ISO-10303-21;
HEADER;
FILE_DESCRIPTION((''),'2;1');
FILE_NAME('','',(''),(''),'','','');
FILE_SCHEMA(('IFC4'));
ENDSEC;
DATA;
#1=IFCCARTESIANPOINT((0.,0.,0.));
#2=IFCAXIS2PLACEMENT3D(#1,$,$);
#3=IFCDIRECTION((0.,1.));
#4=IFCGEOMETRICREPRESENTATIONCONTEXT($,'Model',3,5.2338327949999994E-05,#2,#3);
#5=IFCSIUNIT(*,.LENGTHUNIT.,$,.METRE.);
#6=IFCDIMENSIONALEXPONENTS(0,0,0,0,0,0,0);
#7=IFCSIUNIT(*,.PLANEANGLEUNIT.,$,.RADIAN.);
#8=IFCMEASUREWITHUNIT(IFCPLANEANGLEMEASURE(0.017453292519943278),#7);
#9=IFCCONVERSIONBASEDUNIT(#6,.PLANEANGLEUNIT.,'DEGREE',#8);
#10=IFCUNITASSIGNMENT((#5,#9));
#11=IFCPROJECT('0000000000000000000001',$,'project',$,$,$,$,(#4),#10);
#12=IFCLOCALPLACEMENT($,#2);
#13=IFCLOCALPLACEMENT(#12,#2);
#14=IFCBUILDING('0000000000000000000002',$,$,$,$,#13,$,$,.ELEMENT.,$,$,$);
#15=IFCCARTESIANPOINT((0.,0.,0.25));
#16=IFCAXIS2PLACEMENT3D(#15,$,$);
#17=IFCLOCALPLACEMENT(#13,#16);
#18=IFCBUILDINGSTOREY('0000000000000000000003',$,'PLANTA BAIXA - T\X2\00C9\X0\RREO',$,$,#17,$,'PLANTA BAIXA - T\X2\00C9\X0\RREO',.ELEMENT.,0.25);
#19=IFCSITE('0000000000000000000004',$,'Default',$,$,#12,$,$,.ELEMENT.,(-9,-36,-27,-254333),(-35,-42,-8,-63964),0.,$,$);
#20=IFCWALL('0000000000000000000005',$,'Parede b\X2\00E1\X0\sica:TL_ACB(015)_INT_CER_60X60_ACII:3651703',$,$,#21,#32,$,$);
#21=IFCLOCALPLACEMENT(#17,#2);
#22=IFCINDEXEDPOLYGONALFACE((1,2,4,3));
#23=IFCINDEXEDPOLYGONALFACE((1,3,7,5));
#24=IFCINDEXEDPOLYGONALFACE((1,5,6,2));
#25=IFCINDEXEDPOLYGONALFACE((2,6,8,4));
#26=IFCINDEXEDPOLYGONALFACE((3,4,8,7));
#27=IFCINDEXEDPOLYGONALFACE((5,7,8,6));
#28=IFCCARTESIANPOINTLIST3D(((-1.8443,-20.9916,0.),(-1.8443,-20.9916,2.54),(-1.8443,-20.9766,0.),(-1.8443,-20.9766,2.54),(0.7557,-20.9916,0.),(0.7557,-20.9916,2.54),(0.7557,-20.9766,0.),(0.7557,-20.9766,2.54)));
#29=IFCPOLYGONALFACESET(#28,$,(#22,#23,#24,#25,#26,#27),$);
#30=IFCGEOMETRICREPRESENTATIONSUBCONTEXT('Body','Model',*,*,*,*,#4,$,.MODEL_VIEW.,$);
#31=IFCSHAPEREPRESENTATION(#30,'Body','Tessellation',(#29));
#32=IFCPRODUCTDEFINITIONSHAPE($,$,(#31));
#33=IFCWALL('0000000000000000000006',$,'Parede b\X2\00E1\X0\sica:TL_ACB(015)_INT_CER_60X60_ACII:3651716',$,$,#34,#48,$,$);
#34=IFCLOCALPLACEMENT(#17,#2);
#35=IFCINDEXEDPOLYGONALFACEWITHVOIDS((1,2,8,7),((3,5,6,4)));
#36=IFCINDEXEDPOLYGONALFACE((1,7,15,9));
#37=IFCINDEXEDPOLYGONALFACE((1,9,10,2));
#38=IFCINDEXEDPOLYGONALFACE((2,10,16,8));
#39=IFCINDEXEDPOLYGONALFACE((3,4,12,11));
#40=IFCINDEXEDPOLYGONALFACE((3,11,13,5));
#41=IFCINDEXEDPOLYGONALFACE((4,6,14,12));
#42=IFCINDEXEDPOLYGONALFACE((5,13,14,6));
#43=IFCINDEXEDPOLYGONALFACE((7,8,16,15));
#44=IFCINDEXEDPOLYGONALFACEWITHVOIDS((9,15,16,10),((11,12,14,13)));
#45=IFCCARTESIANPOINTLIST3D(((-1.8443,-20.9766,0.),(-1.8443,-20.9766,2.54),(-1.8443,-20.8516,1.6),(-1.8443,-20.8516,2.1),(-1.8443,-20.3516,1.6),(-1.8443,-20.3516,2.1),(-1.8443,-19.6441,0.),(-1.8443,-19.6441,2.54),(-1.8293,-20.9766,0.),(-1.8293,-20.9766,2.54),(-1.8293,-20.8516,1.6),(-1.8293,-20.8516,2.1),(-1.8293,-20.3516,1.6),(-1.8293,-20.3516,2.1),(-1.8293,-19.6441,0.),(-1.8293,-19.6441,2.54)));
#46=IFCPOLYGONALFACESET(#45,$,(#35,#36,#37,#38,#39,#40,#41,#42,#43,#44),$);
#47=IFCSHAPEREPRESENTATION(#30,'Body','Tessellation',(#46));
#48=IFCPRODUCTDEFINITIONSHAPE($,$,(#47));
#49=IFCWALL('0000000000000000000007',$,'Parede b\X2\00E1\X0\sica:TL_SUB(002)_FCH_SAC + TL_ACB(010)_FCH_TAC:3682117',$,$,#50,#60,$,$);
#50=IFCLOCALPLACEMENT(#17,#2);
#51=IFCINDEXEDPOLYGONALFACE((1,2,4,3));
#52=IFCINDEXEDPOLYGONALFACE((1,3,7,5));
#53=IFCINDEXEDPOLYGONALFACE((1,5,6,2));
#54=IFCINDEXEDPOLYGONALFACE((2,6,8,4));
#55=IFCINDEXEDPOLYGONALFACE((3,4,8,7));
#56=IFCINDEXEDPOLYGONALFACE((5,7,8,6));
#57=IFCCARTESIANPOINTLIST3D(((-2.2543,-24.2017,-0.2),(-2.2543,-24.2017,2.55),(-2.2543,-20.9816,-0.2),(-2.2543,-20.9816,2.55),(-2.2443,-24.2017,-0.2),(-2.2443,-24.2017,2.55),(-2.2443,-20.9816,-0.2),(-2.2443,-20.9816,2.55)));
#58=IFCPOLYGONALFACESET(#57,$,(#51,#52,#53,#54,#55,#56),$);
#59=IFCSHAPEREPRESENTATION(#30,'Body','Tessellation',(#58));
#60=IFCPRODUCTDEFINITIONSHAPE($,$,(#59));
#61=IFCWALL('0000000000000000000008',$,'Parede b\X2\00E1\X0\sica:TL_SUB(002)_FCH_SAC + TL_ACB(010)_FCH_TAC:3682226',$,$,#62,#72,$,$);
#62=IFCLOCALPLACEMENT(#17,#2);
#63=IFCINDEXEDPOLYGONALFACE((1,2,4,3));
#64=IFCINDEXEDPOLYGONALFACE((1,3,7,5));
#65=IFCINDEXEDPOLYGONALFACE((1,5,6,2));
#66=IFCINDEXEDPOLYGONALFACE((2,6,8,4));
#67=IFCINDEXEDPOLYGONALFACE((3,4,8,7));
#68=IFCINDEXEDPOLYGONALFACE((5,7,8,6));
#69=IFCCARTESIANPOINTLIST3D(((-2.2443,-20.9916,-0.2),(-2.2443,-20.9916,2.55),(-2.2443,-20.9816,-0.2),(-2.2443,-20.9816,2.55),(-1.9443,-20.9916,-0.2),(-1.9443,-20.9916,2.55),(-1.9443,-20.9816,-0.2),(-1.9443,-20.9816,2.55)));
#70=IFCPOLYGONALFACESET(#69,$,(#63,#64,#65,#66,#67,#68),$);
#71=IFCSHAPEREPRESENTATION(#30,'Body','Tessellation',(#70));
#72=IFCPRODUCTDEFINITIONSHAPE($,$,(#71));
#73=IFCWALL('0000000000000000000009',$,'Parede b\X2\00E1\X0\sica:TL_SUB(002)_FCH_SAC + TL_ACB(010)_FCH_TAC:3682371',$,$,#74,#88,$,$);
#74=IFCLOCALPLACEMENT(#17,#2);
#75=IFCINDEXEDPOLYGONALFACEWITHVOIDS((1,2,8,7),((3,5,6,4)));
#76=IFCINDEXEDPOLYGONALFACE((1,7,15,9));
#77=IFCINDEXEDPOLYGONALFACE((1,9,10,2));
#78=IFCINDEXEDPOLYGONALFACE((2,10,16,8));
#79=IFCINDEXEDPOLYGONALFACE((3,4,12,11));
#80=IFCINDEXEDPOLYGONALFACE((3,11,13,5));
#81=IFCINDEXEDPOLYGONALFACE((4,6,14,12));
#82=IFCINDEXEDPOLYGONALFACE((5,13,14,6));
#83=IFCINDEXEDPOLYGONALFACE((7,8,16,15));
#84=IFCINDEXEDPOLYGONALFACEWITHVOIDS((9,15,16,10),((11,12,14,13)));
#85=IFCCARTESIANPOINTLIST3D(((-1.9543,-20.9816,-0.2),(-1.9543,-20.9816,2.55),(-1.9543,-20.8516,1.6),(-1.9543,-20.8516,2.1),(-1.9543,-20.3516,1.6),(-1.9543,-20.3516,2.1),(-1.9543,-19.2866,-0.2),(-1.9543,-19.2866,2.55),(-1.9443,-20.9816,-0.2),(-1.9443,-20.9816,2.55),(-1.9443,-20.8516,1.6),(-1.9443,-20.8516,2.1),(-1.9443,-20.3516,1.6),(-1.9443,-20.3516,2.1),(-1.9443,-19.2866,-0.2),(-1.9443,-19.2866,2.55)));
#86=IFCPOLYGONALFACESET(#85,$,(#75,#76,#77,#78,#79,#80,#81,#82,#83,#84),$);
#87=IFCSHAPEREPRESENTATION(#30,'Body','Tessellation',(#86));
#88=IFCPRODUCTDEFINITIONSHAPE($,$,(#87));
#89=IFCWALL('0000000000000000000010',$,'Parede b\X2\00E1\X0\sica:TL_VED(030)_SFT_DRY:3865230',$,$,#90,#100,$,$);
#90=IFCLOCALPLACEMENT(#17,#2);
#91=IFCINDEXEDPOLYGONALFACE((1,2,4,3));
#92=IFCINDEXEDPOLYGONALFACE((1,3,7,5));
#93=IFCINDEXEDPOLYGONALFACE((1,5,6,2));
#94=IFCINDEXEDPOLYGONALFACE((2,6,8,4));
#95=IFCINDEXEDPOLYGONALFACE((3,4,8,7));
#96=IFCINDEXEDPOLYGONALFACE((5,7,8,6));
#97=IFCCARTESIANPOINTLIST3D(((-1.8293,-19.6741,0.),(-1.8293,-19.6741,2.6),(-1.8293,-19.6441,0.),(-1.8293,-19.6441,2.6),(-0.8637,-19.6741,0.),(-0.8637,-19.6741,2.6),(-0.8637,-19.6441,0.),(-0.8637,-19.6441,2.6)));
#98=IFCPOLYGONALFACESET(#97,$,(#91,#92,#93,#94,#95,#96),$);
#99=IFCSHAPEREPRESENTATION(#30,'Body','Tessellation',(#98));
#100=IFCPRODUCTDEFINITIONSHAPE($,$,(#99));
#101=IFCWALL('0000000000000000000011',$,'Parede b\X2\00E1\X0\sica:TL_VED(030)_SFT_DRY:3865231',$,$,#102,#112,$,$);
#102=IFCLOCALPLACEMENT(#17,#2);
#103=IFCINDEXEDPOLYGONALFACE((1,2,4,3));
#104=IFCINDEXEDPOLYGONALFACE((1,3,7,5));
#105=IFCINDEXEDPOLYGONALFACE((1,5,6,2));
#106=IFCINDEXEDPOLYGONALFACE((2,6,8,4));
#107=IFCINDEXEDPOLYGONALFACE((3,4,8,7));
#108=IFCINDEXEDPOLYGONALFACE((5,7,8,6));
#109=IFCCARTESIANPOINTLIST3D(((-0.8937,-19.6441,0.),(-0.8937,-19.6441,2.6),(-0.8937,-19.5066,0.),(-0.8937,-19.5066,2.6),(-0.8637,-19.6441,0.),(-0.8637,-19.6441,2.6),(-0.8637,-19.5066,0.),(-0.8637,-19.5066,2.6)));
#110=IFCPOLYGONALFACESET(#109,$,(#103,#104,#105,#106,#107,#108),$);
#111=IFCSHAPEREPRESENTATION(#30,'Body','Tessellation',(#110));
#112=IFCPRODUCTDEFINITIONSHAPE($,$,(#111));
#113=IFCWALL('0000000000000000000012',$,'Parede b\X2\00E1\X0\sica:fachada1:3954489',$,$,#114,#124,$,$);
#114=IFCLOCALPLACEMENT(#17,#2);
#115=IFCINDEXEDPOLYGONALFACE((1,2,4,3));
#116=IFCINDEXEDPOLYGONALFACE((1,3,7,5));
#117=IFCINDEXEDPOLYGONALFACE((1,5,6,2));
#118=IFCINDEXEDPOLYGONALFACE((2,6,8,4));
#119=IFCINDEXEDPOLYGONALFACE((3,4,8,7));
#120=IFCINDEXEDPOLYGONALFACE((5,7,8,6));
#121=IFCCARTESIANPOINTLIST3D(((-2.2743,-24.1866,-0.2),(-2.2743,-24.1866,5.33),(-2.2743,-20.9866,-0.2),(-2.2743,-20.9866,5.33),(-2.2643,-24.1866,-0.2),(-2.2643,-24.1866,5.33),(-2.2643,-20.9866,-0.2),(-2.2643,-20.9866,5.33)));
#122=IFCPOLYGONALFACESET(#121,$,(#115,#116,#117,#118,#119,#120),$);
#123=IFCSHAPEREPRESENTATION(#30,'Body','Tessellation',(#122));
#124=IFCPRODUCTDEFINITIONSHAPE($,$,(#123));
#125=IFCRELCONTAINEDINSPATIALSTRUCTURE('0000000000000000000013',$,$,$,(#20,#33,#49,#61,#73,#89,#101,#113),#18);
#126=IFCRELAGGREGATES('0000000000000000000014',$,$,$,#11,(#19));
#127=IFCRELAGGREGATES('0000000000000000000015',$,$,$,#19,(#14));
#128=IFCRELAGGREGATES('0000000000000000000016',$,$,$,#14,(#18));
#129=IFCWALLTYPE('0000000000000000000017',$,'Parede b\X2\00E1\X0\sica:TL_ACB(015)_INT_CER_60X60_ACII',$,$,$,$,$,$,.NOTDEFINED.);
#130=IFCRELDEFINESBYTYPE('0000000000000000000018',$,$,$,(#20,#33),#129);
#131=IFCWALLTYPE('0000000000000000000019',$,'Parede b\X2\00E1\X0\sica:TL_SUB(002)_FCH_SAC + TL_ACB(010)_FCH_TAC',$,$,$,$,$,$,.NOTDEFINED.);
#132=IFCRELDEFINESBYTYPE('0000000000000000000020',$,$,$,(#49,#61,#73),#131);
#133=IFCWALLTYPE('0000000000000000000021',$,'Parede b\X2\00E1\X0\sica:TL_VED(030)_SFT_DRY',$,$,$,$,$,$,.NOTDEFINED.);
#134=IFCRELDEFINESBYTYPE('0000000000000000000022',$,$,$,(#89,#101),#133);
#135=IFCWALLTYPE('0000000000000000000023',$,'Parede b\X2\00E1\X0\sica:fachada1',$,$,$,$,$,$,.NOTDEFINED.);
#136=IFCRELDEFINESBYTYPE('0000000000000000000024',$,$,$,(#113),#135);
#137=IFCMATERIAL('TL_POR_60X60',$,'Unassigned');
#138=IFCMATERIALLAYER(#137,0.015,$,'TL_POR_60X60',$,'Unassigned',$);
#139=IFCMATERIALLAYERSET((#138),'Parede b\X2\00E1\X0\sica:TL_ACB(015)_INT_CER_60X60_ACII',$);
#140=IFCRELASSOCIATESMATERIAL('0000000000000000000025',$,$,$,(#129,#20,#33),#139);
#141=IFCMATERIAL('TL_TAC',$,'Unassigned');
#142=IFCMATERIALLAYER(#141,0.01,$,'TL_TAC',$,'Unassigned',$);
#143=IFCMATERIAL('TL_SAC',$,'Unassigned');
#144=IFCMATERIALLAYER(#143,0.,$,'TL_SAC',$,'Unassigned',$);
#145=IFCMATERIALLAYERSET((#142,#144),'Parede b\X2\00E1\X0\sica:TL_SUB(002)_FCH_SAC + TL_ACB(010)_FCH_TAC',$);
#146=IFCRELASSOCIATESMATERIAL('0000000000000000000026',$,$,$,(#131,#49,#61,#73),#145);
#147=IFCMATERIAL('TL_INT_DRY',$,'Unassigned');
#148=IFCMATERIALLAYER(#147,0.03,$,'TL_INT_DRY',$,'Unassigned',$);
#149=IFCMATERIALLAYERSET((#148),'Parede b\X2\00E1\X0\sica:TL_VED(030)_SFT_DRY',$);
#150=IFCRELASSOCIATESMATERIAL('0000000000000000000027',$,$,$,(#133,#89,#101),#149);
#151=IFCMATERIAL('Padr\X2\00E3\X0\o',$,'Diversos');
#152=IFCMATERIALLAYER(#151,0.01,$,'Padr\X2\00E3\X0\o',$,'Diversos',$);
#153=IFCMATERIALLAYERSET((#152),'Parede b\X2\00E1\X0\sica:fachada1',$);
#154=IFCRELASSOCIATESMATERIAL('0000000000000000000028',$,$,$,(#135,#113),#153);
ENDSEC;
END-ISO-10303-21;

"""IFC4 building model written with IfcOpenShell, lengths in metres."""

from ifc_helpers import new_model, entity, si_unit, converted_unit, direction, frame, frame_2d, origin, place, context, subcontext, project, spatial, rectangle, extrude, material, layer, layer_set, layer_usage, type_object, element, save


model = new_model("IFC4")

# Units and contexts
model_context = context("Model", 3, precision=5.2338327949999994e-05, world=origin(), true_north=direction((0.0, 1.0)))
body_context = subcontext(model_context, "Body", "Model", "MODEL_VIEW")
ifc_project = project(units=[si_unit("LENGTHUNIT", "METRE"), converted_unit("PLANEANGLEUNIT", "DEGREE", entity("IfcPlaneAngleMeasure", 0.017453292519943278), si_unit("PLANEANGLEUNIT", "RADIAN"), dimensions=[0, 0, 0, 0, 0, 0, 0])], contexts=[model_context])

# Site, building, storey
site_placement = place(None, frame((0.0, 0.0, 0.0)))
site = spatial("IfcSite", under=ifc_project, at=site_placement, Name="Default", CompositionType="ELEMENT", RefLatitude=(-9, -36, -27, -254333), RefLongitude=(-35, -42, -8, -63964), RefElevation=0.0)
building_placement = place(site_placement, origin())
building = spatial("IfcBuilding", under=site, at=building_placement, CompositionType="ELEMENT")
storey_placement = place(building_placement, frame((0.0, 0.0, 0.25)))
storey = spatial("IfcBuildingStorey", under=building, at=storey_placement, Name="PLANTA BAIXA - TÉRREO", LongName="PLANTA BAIXA - TÉRREO", CompositionType="ELEMENT", Elevation=0.25)

# Shared definitions
ifc_material_1 = material(Name="TL_SAC", Category="Unassigned")

# Wall
ifc_material_2 = material(Name="TL_POR_60X60", Category="Unassigned")
ifc_layer_1 = layer(ifc_material_2, 0.015, Name="TL_POR_60X60", Category="Unassigned")
ifc_layer_set_1 = layer_set([ifc_layer_1], Name="Parede básica:TL_ACB(015)_INT_CER_60X60_ACII")
ifc_layer_usage_1 = layer_usage(ifc_layer_set_1, "AXIS2", "NEGATIVE", 0.0075)
wall_type_1 = type_object("IfcWallType", Name="Parede básica:TL_ACB(015)_INT_CER_60X60_ACII", PredefinedType="NOTDEFINED", material=ifc_layer_set_1)
wall_1_placement = place(storey_placement, frame((-1.8443, -20.9841, 0.0)))
element("IfcWall", 1, at=wall_1_placement, inside=storey, type_object=wall_type_1, material=ifc_layer_usage_1, Name="Parede básica:TL_ACB(015)_INT_CER_60X60_ACII:3651703", context=body_context, shape_type="SweptSolid", body=[
    extrude(rectangle(XDim=2.6, YDim=0.015, at=frame_2d((1.3, 0.0), x_axis=(-1.0, 0.0))), origin(), (0.0, 0.0, 1.0), 2.54),
])

# Wall, opening
ifc_layer_usage_2 = layer_usage(ifc_layer_set_1, "AXIS2", "POSITIVE", -0.0075)
wall_2_placement = place(storey_placement, frame((-1.8368, -20.9766, 0.0), z_axis=(0.0, 0.0, 1.0), x_axis=(0.0, 1.0, 0.0)))
wall_2 = element("IfcWall", 2, at=wall_2_placement, inside=storey, type_object=wall_type_1, material=ifc_layer_usage_2, Name="Parede básica:TL_ACB(015)_INT_CER_60X60_ACII:3651716", context=body_context, shape_type="SweptSolid", body=[
    extrude(rectangle(XDim=1.3325, YDim=0.015, at=frame_2d((0.6662, 0.0), x_axis=(-1.0, 0.0))), origin(), (0.0, 0.0, 1.0), 2.54),
])
opening_1_placement = place(wall_2_placement, frame((20.9766, -1.8368, 1.6)))
element("IfcOpeningElement", 3, at=opening_1_placement, cuts=wall_2, PredefinedType="OPENING", context=body_context, shape_type="SweptSolid", body=[
    extrude(rectangle(XDim=0.5, YDim=0.5, at=frame_2d((0.0, 0.0), x_axis=(1.0, 0.0))), frame((-20.6016, 0.4203, 0.25), z_axis=(0.0, 1.0, 0.0), x_axis=(0.0, 0.0, 1.0)), (0.0, 0.0, 1.0), 3.048),
])

# Walls
ifc_material_3 = material(Name="TL_TAC", Category="Unassigned")
ifc_layer_2 = layer(ifc_material_3, 0.01, Name="TL_TAC", Category="Unassigned")
ifc_layer_3 = layer(ifc_material_1, 0.0, Name="TL_SAC", Category="Unassigned")
ifc_layer_set_2 = layer_set([ifc_layer_2, ifc_layer_3], Name="Parede básica:TL_SUB(002)_FCH_SAC + TL_ACB(010)_FCH_TAC")
ifc_layer_usage_3 = layer_usage(ifc_layer_set_2, "AXIS2", "POSITIVE", -0.005)
wall_type_2 = type_object("IfcWallType", Name="Parede básica:TL_SUB(002)_FCH_SAC + TL_ACB(010)_FCH_TAC", PredefinedType="NOTDEFINED", material=ifc_layer_set_2)
wall_3_placement = place(storey_placement, frame((-2.2493, -24.2017, -0.2), z_axis=(0.0, 0.0, 1.0), x_axis=(0.0, 1.0, 0.0)))
element("IfcWall", 4, at=wall_3_placement, inside=storey, type_object=wall_type_2, material=ifc_layer_usage_3, Name="Parede básica:TL_SUB(002)_FCH_SAC + TL_ACB(010)_FCH_TAC:3682117", context=body_context, shape_type="SweptSolid", body=[
    extrude(rectangle(XDim=3.2201, YDim=0.01, at=frame_2d((1.6101, 0.0), x_axis=(-1.0, 0.0))), origin(), (0.0, 0.0, 1.0), 2.75),
])
ifc_layer_usage_4 = layer_usage(ifc_layer_set_2, "AXIS2", "POSITIVE", -0.005)
wall_4_placement = place(storey_placement, frame((-2.2443, -20.9866, -0.2)))
element("IfcWall", 5, at=wall_4_placement, inside=storey, type_object=wall_type_2, material=ifc_layer_usage_4, Name="Parede básica:TL_SUB(002)_FCH_SAC + TL_ACB(010)_FCH_TAC:3682226", context=body_context, shape_type="SweptSolid", body=[
    extrude(rectangle(XDim=0.3, YDim=0.01, at=frame_2d((0.15, 0.0), x_axis=(-1.0, 0.0))), origin(), (0.0, 0.0, 1.0), 2.75),
])

# Wall, opening
ifc_layer_usage_5 = layer_usage(ifc_layer_set_2, "AXIS2", "POSITIVE", -0.005)
wall_5_placement = place(storey_placement, frame((-1.9493, -20.9816, -0.2), z_axis=(0.0, 0.0, 1.0), x_axis=(0.0, 1.0, 0.0)))
wall_5 = element("IfcWall", 6, at=wall_5_placement, inside=storey, type_object=wall_type_2, material=ifc_layer_usage_5, Name="Parede básica:TL_SUB(002)_FCH_SAC + TL_ACB(010)_FCH_TAC:3682371", context=body_context, shape_type="SweptSolid", body=[
    extrude(rectangle(XDim=1.695, YDim=0.01, at=frame_2d((0.8475, 0.0), x_axis=(-1.0, 0.0))), origin(), (0.0, 0.0, 1.0), 2.75),
])
opening_2_placement = place(wall_5_placement, frame((20.9816, -1.9493, 1.8)))
element("IfcOpeningElement", 7, at=opening_2_placement, cuts=wall_5, PredefinedType="OPENING", context=body_context, shape_type="SweptSolid", body=[
    extrude(rectangle(XDim=0.5, YDim=0.5, at=frame_2d((0.0, 0.0), x_axis=(1.0, 0.0))), frame((-20.6016, 0.4203, 0.25), z_axis=(0.0, 1.0, 0.0), x_axis=(0.0, 0.0, 1.0)), (0.0, 0.0, 1.0), 3.048),
])

# Walls
ifc_material_4 = material(Name="TL_INT_DRY", Category="Unassigned")
ifc_layer_4 = layer(ifc_material_4, 0.03, Name="TL_INT_DRY", Category="Unassigned")
ifc_layer_set_3 = layer_set([ifc_layer_4], Name="Parede básica:TL_VED(030)_SFT_DRY")
ifc_layer_usage_6 = layer_usage(ifc_layer_set_3, "AXIS2", "POSITIVE", -0.015)
wall_type_3 = type_object("IfcWallType", Name="Parede básica:TL_VED(030)_SFT_DRY", PredefinedType="NOTDEFINED", material=ifc_layer_set_3)
wall_6_placement = place(storey_placement, frame((-1.8293, -19.6591, 0.0)))
element("IfcWall", 8, at=wall_6_placement, inside=storey, type_object=wall_type_3, material=ifc_layer_usage_6, Name="Parede básica:TL_VED(030)_SFT_DRY:3865230", context=body_context, shape_type="SweptSolid", body=[
    extrude(rectangle(XDim=0.9655, YDim=0.03, at=frame_2d((0.4828, 0.0), x_axis=(-1.0, 0.0))), origin(), (0.0, 0.0, 1.0), 2.6),
])
ifc_layer_usage_7 = layer_usage(ifc_layer_set_3, "AXIS2", "POSITIVE", -0.015)
wall_7_placement = place(storey_placement, frame((-0.8787, -19.6441, 0.0), z_axis=(0.0, 0.0, 1.0), x_axis=(0.0, 1.0, 0.0)))
element("IfcWall", 9, at=wall_7_placement, inside=storey, type_object=wall_type_3, material=ifc_layer_usage_7, Name="Parede básica:TL_VED(030)_SFT_DRY:3865231", context=body_context, shape_type="SweptSolid", body=[
    extrude(rectangle(XDim=0.1375, YDim=0.03, at=frame_2d((0.0688, 0.0), x_axis=(-1.0, 0.0))), origin(), (0.0, 0.0, 1.0), 2.6),
])
ifc_material_5 = material(Name="Padrão", Category="Diversos")
ifc_layer_5 = layer(ifc_material_5, 0.01, Name="Padrão", Category="Diversos")
ifc_layer_set_4 = layer_set([ifc_layer_5], Name="Parede básica:fachada1")
ifc_layer_usage_8 = layer_usage(ifc_layer_set_4, "AXIS2", "NEGATIVE", 0.005)
wall_type_4 = type_object("IfcWallType", Name="Parede básica:fachada1", PredefinedType="NOTDEFINED", material=ifc_layer_set_4)
wall_8_placement = place(storey_placement, frame((-2.2693, -20.9866, -0.2), z_axis=(0.0, 0.0, 1.0), x_axis=(0.0, -1.0, 0.0)))
element("IfcWall", 10, at=wall_8_placement, inside=storey, type_object=wall_type_4, material=ifc_layer_usage_8, Name="Parede básica:fachada1:3954489", context=body_context, shape_type="SweptSolid", body=[
    extrude(rectangle(XDim=3.2, YDim=0.01, at=frame_2d((1.6, 0.0), x_axis=(-1.0, 0.0))), origin(), (0.0, 0.0, 1.0), 5.53),
])

save(model, "model.ifc")
